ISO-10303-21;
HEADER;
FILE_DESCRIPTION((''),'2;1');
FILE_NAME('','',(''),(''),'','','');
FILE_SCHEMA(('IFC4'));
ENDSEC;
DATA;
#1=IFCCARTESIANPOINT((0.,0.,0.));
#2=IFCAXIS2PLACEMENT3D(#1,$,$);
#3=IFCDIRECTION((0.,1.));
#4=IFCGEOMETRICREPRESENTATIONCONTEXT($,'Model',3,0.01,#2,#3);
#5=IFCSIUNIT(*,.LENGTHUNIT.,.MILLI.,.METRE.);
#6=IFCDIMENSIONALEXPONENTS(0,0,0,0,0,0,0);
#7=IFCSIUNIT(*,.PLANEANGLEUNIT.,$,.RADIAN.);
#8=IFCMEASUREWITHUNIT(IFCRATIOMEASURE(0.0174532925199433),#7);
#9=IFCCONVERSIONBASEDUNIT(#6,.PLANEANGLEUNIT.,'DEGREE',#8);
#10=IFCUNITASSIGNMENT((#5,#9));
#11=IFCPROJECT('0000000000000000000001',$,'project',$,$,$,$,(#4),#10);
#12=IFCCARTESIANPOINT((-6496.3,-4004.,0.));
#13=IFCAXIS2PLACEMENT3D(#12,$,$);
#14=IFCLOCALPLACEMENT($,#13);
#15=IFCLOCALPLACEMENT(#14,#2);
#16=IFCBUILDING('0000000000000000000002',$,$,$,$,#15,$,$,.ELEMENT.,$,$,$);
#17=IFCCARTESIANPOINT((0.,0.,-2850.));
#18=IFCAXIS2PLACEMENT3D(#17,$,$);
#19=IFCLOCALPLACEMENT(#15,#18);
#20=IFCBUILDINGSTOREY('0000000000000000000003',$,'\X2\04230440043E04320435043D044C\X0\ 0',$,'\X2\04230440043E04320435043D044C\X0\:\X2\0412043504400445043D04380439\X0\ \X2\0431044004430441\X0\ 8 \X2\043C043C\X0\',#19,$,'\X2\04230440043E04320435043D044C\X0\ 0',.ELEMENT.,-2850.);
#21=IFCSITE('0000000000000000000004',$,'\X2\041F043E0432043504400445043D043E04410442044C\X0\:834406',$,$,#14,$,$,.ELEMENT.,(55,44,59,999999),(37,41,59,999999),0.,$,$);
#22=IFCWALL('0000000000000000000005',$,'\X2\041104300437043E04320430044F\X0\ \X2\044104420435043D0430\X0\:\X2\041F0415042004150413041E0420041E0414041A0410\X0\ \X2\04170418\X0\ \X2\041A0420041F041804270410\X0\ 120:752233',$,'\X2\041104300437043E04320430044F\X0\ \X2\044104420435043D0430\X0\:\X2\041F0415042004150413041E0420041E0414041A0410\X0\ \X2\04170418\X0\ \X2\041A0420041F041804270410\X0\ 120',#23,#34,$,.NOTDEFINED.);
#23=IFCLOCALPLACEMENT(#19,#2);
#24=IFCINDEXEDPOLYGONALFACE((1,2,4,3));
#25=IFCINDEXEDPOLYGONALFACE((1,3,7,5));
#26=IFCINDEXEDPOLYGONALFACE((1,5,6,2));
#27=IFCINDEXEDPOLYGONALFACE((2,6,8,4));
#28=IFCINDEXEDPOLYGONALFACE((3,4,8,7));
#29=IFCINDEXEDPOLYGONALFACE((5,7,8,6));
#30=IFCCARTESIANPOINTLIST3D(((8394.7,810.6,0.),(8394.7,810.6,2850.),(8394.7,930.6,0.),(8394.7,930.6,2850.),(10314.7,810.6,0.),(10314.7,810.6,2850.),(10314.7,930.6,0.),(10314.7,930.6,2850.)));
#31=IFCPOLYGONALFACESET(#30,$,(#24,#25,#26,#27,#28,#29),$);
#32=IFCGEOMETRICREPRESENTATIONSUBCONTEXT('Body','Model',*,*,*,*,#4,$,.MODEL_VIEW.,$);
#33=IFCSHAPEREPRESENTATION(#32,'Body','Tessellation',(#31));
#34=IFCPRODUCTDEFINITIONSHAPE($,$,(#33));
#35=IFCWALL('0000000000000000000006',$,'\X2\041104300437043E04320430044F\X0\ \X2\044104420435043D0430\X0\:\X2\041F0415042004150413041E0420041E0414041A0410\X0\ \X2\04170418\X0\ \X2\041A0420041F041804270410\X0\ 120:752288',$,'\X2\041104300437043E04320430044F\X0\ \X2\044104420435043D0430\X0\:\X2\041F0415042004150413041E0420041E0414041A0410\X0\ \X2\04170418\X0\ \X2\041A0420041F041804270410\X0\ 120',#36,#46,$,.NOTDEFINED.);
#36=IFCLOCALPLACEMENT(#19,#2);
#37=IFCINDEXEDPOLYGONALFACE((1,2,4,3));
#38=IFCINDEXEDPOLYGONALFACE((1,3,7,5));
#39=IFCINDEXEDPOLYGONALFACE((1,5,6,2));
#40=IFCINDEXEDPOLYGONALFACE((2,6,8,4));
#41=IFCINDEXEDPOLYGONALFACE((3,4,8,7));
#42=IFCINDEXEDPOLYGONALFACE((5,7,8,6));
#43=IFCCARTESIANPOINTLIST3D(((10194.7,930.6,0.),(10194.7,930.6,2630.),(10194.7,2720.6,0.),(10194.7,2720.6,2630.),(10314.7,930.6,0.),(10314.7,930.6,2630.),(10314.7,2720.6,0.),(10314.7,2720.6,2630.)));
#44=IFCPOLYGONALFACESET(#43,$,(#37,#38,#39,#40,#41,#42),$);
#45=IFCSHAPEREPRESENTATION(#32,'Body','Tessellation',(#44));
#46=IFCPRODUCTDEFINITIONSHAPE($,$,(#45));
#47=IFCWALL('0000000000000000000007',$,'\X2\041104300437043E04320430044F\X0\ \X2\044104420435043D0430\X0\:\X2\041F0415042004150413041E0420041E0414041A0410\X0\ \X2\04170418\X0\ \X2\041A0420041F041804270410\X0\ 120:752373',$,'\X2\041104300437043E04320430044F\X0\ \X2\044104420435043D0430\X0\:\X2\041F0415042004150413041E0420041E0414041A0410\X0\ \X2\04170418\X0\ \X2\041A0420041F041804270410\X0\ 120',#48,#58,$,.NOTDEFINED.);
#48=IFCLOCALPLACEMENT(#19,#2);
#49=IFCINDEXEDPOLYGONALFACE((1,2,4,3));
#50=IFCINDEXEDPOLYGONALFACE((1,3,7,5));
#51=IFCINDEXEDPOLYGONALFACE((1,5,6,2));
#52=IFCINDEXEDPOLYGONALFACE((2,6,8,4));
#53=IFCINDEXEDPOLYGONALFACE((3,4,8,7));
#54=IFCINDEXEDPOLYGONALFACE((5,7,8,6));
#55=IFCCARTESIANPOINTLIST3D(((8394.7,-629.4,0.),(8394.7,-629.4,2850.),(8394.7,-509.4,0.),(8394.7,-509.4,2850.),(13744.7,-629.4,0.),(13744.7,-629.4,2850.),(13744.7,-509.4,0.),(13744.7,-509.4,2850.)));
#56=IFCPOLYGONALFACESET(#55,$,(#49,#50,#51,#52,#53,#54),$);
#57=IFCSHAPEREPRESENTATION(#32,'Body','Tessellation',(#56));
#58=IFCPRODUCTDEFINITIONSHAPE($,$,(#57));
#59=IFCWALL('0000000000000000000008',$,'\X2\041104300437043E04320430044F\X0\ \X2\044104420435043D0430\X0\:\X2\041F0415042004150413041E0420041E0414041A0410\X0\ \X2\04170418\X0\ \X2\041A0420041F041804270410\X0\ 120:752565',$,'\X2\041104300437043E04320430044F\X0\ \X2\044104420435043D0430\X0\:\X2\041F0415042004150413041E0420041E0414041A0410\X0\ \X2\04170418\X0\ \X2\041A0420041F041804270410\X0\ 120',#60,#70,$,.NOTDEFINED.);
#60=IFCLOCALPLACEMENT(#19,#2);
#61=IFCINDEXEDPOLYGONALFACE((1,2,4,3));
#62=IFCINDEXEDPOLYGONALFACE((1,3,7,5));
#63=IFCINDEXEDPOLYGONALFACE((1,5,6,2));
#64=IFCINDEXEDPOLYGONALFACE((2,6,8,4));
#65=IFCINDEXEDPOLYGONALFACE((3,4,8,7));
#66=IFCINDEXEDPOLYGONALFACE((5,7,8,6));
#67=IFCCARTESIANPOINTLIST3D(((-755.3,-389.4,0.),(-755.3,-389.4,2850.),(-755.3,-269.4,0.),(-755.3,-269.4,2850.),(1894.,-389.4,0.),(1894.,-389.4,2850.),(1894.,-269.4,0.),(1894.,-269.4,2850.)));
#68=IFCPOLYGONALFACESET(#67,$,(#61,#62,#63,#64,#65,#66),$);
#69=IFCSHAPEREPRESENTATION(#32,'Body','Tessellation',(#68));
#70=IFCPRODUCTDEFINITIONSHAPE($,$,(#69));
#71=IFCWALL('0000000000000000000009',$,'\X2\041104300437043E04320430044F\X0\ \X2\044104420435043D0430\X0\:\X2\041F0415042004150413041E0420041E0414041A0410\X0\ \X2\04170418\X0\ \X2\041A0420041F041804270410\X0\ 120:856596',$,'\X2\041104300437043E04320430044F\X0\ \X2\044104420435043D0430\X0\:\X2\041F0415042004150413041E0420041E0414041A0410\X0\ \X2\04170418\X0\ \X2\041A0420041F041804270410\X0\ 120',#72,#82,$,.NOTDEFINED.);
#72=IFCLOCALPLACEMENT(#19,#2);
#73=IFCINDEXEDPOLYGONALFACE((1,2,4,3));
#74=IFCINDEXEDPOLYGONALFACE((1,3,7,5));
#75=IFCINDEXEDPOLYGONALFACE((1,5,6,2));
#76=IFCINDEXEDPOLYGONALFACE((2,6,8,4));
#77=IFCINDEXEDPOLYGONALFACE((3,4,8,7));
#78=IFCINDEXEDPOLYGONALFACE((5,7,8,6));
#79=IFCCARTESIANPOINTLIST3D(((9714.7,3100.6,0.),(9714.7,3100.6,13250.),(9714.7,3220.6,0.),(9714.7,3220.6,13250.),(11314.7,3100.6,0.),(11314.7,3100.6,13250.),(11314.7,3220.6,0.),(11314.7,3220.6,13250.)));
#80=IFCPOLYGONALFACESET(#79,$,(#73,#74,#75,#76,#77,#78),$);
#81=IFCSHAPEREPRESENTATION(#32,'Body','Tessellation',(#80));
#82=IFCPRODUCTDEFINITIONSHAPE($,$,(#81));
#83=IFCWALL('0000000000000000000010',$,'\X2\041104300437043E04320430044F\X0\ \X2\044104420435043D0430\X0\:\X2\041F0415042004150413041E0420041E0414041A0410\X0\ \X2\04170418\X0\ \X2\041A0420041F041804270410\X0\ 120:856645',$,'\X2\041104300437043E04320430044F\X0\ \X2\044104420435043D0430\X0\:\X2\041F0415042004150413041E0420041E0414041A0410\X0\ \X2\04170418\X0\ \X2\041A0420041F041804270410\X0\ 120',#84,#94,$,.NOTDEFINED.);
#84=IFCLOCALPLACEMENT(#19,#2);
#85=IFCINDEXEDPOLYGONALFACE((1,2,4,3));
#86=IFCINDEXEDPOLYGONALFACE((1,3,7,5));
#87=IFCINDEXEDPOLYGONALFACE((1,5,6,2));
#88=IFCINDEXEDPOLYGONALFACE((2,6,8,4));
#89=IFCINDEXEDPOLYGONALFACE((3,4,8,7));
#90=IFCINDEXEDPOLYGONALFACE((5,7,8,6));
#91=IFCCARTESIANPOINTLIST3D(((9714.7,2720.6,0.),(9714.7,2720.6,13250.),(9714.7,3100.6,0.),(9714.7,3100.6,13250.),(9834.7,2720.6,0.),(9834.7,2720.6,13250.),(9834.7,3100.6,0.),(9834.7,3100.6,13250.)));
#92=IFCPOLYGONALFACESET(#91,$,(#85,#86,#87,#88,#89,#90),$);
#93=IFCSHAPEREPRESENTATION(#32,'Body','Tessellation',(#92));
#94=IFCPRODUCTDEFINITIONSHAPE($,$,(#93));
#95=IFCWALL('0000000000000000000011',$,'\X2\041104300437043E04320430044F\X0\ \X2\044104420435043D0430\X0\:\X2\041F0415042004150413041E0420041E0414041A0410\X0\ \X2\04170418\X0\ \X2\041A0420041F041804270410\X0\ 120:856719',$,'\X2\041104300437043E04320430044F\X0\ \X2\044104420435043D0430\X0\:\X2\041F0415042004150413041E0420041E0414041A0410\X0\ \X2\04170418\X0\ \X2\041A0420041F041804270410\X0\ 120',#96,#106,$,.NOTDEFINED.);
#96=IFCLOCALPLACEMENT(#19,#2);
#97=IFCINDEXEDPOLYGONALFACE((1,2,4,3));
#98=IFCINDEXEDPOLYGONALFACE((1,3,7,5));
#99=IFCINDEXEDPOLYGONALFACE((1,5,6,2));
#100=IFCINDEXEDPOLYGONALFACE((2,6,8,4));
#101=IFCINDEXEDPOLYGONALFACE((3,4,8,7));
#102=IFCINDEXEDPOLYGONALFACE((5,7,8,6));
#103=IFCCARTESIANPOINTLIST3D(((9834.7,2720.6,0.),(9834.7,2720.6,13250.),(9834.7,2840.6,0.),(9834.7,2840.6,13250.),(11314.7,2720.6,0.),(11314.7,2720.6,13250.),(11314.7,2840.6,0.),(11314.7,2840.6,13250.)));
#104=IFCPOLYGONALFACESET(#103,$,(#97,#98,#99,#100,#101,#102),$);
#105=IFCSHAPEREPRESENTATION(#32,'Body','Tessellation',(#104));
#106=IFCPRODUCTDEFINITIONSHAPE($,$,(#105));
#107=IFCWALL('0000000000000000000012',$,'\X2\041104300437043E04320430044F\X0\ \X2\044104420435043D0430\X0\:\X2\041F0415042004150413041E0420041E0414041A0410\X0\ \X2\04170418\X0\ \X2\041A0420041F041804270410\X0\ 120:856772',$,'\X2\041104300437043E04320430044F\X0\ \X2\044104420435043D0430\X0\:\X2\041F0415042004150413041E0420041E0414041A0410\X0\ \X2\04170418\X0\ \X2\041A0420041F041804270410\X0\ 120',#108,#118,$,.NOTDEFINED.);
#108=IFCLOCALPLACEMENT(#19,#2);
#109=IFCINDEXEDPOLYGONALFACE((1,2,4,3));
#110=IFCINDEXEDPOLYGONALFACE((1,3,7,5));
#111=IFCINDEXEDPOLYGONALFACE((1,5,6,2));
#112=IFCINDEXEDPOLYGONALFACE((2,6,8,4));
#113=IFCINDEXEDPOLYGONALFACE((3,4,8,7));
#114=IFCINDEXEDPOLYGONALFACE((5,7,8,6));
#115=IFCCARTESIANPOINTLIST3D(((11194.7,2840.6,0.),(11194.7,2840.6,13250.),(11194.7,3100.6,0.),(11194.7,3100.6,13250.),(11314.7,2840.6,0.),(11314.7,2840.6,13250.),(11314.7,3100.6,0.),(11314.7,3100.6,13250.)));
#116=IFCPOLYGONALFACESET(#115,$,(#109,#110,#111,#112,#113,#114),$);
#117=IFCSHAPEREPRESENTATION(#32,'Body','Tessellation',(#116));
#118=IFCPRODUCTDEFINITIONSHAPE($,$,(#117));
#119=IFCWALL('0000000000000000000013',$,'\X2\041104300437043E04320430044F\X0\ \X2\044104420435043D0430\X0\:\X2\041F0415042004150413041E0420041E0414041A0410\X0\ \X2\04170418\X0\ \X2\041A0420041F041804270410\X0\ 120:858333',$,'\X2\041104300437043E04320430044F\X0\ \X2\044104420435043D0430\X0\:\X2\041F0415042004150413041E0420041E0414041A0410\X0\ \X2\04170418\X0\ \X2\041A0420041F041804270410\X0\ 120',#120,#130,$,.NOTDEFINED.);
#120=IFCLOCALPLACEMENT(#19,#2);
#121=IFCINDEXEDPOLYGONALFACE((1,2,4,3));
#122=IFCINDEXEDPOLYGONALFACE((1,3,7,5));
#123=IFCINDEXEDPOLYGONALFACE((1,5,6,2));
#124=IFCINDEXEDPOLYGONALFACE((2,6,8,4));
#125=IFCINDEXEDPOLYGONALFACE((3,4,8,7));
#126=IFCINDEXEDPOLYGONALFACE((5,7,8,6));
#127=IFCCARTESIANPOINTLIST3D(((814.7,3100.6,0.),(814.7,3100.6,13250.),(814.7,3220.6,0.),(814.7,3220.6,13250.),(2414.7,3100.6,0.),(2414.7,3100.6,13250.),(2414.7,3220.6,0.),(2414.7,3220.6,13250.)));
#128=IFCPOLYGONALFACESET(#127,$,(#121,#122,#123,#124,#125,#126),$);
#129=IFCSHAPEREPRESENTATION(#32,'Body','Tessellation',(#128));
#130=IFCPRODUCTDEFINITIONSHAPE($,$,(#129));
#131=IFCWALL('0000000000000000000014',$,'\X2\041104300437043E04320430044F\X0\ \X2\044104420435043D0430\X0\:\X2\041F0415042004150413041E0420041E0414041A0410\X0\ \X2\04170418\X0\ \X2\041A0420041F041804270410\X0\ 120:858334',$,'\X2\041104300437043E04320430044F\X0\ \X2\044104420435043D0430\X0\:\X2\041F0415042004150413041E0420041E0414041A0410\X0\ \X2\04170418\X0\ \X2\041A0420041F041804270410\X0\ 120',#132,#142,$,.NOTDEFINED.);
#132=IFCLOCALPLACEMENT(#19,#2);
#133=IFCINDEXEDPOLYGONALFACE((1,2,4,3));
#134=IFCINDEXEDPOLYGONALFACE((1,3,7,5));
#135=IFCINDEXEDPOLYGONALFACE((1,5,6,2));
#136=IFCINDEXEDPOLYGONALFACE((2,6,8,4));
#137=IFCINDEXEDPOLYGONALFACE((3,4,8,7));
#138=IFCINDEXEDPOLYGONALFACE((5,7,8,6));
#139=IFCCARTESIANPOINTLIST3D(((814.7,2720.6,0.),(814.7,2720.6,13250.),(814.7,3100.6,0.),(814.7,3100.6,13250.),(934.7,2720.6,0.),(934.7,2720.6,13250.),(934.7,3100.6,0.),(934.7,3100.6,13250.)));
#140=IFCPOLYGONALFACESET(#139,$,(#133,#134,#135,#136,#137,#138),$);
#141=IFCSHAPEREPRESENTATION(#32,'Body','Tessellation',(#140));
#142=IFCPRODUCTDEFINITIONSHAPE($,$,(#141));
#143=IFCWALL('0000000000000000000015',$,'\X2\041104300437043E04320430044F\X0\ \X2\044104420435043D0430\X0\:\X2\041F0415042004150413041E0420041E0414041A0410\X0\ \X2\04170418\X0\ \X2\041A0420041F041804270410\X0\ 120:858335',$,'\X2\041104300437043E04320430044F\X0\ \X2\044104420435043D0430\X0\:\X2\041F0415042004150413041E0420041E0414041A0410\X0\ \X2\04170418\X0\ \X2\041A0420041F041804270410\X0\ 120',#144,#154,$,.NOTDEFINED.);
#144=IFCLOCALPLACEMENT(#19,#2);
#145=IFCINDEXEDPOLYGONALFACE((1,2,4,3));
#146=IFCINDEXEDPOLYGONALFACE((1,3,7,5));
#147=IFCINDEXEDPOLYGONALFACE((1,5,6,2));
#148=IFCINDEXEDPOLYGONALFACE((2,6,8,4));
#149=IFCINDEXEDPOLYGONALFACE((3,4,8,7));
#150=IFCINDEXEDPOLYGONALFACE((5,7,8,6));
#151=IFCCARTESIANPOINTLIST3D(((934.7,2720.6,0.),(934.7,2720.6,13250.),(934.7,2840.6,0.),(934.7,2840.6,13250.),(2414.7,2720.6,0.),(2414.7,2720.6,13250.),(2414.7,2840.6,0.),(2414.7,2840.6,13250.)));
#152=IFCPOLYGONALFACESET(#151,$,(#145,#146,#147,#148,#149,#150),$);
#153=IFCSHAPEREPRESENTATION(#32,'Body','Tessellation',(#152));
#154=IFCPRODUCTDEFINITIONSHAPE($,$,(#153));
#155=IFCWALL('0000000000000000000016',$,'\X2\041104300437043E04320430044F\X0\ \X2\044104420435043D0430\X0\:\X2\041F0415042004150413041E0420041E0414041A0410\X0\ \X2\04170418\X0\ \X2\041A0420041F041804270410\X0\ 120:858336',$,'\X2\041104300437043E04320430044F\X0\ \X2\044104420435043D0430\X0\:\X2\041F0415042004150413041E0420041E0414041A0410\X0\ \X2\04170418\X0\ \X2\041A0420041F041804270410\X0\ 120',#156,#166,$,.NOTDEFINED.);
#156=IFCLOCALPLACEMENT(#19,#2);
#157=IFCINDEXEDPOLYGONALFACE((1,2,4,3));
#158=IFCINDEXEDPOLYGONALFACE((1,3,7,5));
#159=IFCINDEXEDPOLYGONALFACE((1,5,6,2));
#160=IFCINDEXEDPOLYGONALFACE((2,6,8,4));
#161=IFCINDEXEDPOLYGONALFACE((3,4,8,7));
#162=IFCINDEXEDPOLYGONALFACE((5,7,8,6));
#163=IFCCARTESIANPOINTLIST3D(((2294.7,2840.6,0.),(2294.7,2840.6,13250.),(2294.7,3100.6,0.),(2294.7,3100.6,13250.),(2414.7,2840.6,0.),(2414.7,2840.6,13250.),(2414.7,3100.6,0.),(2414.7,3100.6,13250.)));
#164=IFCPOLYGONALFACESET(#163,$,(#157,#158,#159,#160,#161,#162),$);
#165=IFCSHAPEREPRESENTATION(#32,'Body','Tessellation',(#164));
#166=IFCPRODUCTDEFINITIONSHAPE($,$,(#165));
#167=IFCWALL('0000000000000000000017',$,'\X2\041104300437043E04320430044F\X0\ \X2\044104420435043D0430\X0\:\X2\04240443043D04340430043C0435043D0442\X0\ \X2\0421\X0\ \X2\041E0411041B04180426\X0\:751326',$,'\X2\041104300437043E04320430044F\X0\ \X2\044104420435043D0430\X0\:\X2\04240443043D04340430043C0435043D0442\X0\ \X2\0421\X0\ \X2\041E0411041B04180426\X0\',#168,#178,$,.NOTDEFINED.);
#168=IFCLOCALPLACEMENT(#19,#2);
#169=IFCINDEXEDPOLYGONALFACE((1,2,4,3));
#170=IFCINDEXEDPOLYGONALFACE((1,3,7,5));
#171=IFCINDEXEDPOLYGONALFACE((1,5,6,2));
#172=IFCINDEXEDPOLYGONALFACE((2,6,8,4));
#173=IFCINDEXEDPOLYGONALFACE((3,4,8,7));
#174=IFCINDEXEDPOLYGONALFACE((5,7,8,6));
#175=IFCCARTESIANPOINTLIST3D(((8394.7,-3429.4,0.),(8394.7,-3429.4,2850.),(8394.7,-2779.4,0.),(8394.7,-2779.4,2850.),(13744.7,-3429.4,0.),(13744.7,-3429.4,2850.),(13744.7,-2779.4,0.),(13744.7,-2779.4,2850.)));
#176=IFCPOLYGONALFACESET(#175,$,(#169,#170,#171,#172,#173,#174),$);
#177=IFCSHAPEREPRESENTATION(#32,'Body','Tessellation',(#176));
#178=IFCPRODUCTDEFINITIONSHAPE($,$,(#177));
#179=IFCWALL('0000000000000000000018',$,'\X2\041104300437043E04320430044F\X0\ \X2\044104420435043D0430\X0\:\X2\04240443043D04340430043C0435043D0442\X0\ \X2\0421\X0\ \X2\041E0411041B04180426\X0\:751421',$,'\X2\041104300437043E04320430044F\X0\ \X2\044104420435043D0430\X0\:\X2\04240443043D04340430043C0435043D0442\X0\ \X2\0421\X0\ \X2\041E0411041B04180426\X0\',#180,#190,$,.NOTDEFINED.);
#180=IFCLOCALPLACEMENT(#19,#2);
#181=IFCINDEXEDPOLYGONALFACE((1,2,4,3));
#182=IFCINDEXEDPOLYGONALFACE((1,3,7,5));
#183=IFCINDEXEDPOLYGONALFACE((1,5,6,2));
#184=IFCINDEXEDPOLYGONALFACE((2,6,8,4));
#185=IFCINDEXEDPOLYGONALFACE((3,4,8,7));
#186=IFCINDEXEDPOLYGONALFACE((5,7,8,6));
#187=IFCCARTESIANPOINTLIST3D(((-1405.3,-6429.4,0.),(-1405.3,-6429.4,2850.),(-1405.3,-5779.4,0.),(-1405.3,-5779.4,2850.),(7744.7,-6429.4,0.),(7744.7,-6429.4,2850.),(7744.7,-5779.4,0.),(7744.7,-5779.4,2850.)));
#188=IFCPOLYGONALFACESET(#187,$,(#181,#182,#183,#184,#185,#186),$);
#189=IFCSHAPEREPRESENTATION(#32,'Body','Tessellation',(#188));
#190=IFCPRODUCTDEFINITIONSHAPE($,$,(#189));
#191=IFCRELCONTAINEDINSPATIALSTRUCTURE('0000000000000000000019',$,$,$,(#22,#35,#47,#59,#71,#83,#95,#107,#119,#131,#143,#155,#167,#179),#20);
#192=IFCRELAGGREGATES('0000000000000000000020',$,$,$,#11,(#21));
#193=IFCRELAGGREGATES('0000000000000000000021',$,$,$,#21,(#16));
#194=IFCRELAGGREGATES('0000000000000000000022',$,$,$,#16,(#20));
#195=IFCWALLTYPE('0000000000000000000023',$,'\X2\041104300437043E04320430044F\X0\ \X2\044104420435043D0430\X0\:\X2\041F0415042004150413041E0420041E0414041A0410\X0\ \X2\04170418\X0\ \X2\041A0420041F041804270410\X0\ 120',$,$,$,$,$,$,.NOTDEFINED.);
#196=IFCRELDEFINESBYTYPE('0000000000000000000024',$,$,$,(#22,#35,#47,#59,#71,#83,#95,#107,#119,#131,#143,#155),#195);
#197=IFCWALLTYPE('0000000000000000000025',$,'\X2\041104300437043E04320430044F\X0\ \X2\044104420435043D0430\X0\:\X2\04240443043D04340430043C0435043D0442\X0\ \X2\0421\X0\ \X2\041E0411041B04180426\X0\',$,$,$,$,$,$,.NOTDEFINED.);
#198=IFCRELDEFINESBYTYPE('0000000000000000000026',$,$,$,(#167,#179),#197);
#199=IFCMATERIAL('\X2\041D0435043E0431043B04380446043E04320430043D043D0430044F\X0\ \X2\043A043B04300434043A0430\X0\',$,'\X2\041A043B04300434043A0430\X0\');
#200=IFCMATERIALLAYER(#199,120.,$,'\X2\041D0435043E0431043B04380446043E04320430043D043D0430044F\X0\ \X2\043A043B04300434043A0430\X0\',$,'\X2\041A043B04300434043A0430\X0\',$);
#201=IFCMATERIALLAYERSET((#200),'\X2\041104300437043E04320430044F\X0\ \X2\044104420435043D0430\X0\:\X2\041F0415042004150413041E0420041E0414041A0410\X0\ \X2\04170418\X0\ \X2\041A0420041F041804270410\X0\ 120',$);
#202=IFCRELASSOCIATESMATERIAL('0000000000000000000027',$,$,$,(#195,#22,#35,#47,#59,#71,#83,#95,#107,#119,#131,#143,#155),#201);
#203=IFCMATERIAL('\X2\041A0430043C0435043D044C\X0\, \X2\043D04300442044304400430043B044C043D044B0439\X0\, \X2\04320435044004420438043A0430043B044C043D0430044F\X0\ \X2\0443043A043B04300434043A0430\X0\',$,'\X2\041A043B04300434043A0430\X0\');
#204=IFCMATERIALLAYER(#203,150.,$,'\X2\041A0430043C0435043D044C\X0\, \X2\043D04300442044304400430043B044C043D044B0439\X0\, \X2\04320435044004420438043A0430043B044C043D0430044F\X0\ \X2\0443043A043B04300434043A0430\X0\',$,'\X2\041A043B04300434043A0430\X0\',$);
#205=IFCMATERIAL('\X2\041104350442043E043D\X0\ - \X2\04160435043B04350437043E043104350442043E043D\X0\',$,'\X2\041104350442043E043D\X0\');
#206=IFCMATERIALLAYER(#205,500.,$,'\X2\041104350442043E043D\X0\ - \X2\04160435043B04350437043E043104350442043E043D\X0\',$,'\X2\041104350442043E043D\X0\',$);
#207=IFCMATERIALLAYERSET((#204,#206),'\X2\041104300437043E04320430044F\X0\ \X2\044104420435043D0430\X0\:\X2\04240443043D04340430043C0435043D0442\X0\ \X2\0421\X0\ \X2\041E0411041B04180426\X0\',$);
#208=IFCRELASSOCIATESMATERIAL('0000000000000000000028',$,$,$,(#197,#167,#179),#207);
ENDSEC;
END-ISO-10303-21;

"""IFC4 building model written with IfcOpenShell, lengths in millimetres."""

from ifc_helpers import new_model, entity, si_unit, converted_unit, direction, frame, origin, place, context, subcontext, project, spatial, indexed_curve, outline, extrude, material, layer, layer_set, type_object, element, save


model = new_model("IFC4")

# Units and contexts
model_context = context("Model", 3, precision=0.01, world=origin(), true_north=direction((0.0, 1.0)))
body_context = subcontext(model_context, "Body", "Model", "MODEL_VIEW")
ifc_project = project(units=[si_unit("LENGTHUNIT", "METRE", prefix="MILLI"), converted_unit("PLANEANGLEUNIT", "DEGREE", entity("IfcRatioMeasure", 0.0174532925199433), si_unit("PLANEANGLEUNIT", "RADIAN"), dimensions=[0, 0, 0, 0, 0, 0, 0])], contexts=[model_context])

# Site, building, storey
site_placement = place(None, frame((-6496.3, -4004.0, 0.0)))
site = spatial("IfcSite", under=ifc_project, at=site_placement, Name="Поверхность:834406", CompositionType="ELEMENT", RefLatitude=(55, 44, 59, 999999), RefLongitude=(37, 41, 59, 999999), RefElevation=0.0)
building_placement = place(site_placement, origin())
building = spatial("IfcBuilding", under=site, at=building_placement, CompositionType="ELEMENT")
storey_placement = place(building_placement, frame((0.0, 0.0, -2850.0)))
storey = spatial("IfcBuildingStorey", under=building, at=storey_placement, Name="Уровень 0", ObjectType="Уровень:Верхний брус 8 мм", LongName="Уровень 0", CompositionType="ELEMENT", Elevation=-2850.0)

# Shared definitions
ifc_material_1 = material(Name="Бетон - Железобетон", Category="Бетон")

# Walls
ifc_material_2 = material(Name="Необлицованная кладка", Category="Кладка")
ifc_layer_1 = layer(ifc_material_2, 120.0, Name="Необлицованная кладка", Category="Кладка")
ifc_layer_set_1 = layer_set([ifc_layer_1], Name="Базовая стена:ПЕРЕГОРОДКА ЗИ КРПИЧА 120")
wall_type_1 = type_object("IfcWallType", Name="Базовая стена:ПЕРЕГОРОДКА ЗИ КРПИЧА 120", PredefinedType="NOTDEFINED", material=ifc_layer_set_1)
wall_1_placement = place(storey_placement, frame((8394.7, 870.6, 0.0)))
element("IfcWall", 1, at=wall_1_placement, inside=storey, type_object=wall_type_1, material=ifc_layer_set_1, Name="Базовая стена:ПЕРЕГОРОДКА ЗИ КРПИЧА 120:752233", ObjectType="Базовая стена:ПЕРЕГОРОДКА ЗИ КРПИЧА 120", PredefinedType="NOTDEFINED", context=body_context, shape_type="SweptSolid", body=[
    extrude(outline(indexed_curve([(1920.0, 60.0), (0.0, 60.0), (0.0, -60.0), (1920.0, -60.0), (1920.0, 60.0)], self_intersect=False)), origin(), (0.0, 0.0, 1.0), 2850.0),
])
wall_2_placement = place(storey_placement, frame((10254.7, 930.6, 0.0), z_axis=(0.0, 0.0, 1.0), x_axis=(0.0, 1.0, 0.0)))
element("IfcWall", 2, at=wall_2_placement, inside=storey, type_object=wall_type_1, material=ifc_layer_set_1, Name="Базовая стена:ПЕРЕГОРОДКА ЗИ КРПИЧА 120:752288", ObjectType="Базовая стена:ПЕРЕГОРОДКА ЗИ КРПИЧА 120", PredefinedType="NOTDEFINED", context=body_context, shape_type="SweptSolid", body=[
    extrude(outline(indexed_curve([(1790.0, 60.0), (0.0, 60.0), (0.0, -60.0), (1790.0, -60.0), (1790.0, 60.0)], self_intersect=False)), origin(), (0.0, 0.0, 1.0), 2630.0),
])
wall_3_placement = place(storey_placement, frame((8394.7, -569.4, 0.0)))
element("IfcWall", 3, at=wall_3_placement, inside=storey, type_object=wall_type_1, material=ifc_layer_set_1, Name="Базовая стена:ПЕРЕГОРОДКА ЗИ КРПИЧА 120:752373", ObjectType="Базовая стена:ПЕРЕГОРОДКА ЗИ КРПИЧА 120", PredefinedType="NOTDEFINED", context=body_context, shape_type="SweptSolid", body=[
    extrude(outline(indexed_curve([(5350.0, 60.0), (0.0, 60.0), (0.0, -60.0), (5350.0, -60.0), (5350.0, 60.0)], self_intersect=False)), origin(), (0.0, 0.0, 1.0), 2850.0),
])
wall_4_placement = place(storey_placement, frame((1894.0, -329.4, 0.0), z_axis=(0.0, 0.0, 1.0), x_axis=(-1.0, 0.0, 0.0)))
element("IfcWall", 4, at=wall_4_placement, inside=storey, type_object=wall_type_1, material=ifc_layer_set_1, Name="Базовая стена:ПЕРЕГОРОДКА ЗИ КРПИЧА 120:752565", ObjectType="Базовая стена:ПЕРЕГОРОДКА ЗИ КРПИЧА 120", PredefinedType="NOTDEFINED", context=body_context, shape_type="SweptSolid", body=[
    extrude(outline(indexed_curve([(2649.4, 60.0), (0.0, 60.0), (0.0, -60.0), (2649.4, -60.0), (2649.4, 60.0)], self_intersect=False)), origin(), (0.0, 0.0, 1.0), 2850.0),
])
wall_5_placement = place(storey_placement, frame((11314.7, 3160.6, 0.0), z_axis=(0.0, 0.0, 1.0), x_axis=(-1.0, 0.0, 0.0)))
element("IfcWall", 5, at=wall_5_placement, inside=storey, type_object=wall_type_1, material=ifc_layer_set_1, Name="Базовая стена:ПЕРЕГОРОДКА ЗИ КРПИЧА 120:856596", ObjectType="Базовая стена:ПЕРЕГОРОДКА ЗИ КРПИЧА 120", PredefinedType="NOTDEFINED", context=body_context, shape_type="SweptSolid", body=[
    extrude(outline(indexed_curve([(1600.0, 60.0), (0.0, 60.0), (0.0, -60.0), (1600.0, -60.0), (1600.0, 60.0)], self_intersect=False)), origin(), (0.0, 0.0, 1.0), 13250.0),
])
wall_6_placement = place(storey_placement, frame((9774.7, 3100.6, 0.0), z_axis=(0.0, 0.0, 1.0), x_axis=(0.0, -1.0, 0.0)))
element("IfcWall", 6, at=wall_6_placement, inside=storey, type_object=wall_type_1, material=ifc_layer_set_1, Name="Базовая стена:ПЕРЕГОРОДКА ЗИ КРПИЧА 120:856645", ObjectType="Базовая стена:ПЕРЕГОРОДКА ЗИ КРПИЧА 120", PredefinedType="NOTDEFINED", context=body_context, shape_type="SweptSolid", body=[
    extrude(outline(indexed_curve([(380.0, 60.0), (0.0, 60.0), (0.0, -60.0), (380.0, -60.0), (380.0, 60.0)], self_intersect=False)), origin(), (0.0, 0.0, 1.0), 13250.0),
])
wall_7_placement = place(storey_placement, frame((9834.7, 2780.6, 0.0)))
element("IfcWall", 7, at=wall_7_placement, inside=storey, type_object=wall_type_1, material=ifc_layer_set_1, Name="Базовая стена:ПЕРЕГОРОДКА ЗИ КРПИЧА 120:856719", ObjectType="Базовая стена:ПЕРЕГОРОДКА ЗИ КРПИЧА 120", PredefinedType="NOTDEFINED", context=body_context, shape_type="SweptSolid", body=[
    extrude(outline(indexed_curve([(1480.0, 60.0), (0.0, 60.0), (0.0, -60.0), (1480.0, -60.0), (1480.0, 60.0)], self_intersect=False)), origin(), (0.0, 0.0, 1.0), 13250.0),
])
wall_8_placement = place(storey_placement, frame((11254.7, 2840.6, 0.0), z_axis=(0.0, 0.0, 1.0), x_axis=(0.0, 1.0, 0.0)))
element("IfcWall", 8, at=wall_8_placement, inside=storey, type_object=wall_type_1, material=ifc_layer_set_1, Name="Базовая стена:ПЕРЕГОРОДКА ЗИ КРПИЧА 120:856772", ObjectType="Базовая стена:ПЕРЕГОРОДКА ЗИ КРПИЧА 120", PredefinedType="NOTDEFINED", context=body_context, shape_type="SweptSolid", body=[
    extrude(outline(indexed_curve([(260.0, 60.0), (0.0, 60.0), (0.0, -60.0), (260.0, -60.0), (260.0, 60.0)], self_intersect=False)), origin(), (0.0, 0.0, 1.0), 13250.0),
])
wall_9_placement = place(storey_placement, frame((2414.7, 3160.6, 0.0), z_axis=(0.0, 0.0, 1.0), x_axis=(-1.0, 0.0, 0.0)))
element("IfcWall", 9, at=wall_9_placement, inside=storey, type_object=wall_type_1, material=ifc_layer_set_1, Name="Базовая стена:ПЕРЕГОРОДКА ЗИ КРПИЧА 120:858333", ObjectType="Базовая стена:ПЕРЕГОРОДКА ЗИ КРПИЧА 120", PredefinedType="NOTDEFINED", context=body_context, shape_type="SweptSolid", body=[
    extrude(outline(indexed_curve([(1600.0, 60.0), (0.0, 60.0), (0.0, -60.0), (1600.0, -60.0), (1600.0, 60.0)], self_intersect=False)), origin(), (0.0, 0.0, 1.0), 13250.0),
])
wall_10_placement = place(storey_placement, frame((874.7, 3100.6, 0.0), z_axis=(0.0, 0.0, 1.0), x_axis=(0.0, -1.0, 0.0)))
element("IfcWall", 10, at=wall_10_placement, inside=storey, type_object=wall_type_1, material=ifc_layer_set_1, Name="Базовая стена:ПЕРЕГОРОДКА ЗИ КРПИЧА 120:858334", ObjectType="Базовая стена:ПЕРЕГОРОДКА ЗИ КРПИЧА 120", PredefinedType="NOTDEFINED", context=body_context, shape_type="SweptSolid", body=[
    extrude(outline(indexed_curve([(380.0, 60.0), (0.0, 60.0), (0.0, -60.0), (380.0, -60.0), (380.0, 60.0)], self_intersect=False)), origin(), (0.0, 0.0, 1.0), 13250.0),
])
wall_11_placement = place(storey_placement, frame((934.7, 2780.6, 0.0)))
element("IfcWall", 11, at=wall_11_placement, inside=storey, type_object=wall_type_1, material=ifc_layer_set_1, Name="Базовая стена:ПЕРЕГОРОДКА ЗИ КРПИЧА 120:858335", ObjectType="Базовая стена:ПЕРЕГОРОДКА ЗИ КРПИЧА 120", PredefinedType="NOTDEFINED", context=body_context, shape_type="SweptSolid", body=[
    extrude(outline(indexed_curve([(1480.0, 60.0), (0.0, 60.0), (0.0, -60.0), (1480.0, -60.0), (1480.0, 60.0)], self_intersect=False)), origin(), (0.0, 0.0, 1.0), 13250.0),
])
wall_12_placement = place(storey_placement, frame((2354.7, 2840.6, 0.0), z_axis=(0.0, 0.0, 1.0), x_axis=(0.0, 1.0, 0.0)))
element("IfcWall", 12, at=wall_12_placement, inside=storey, type_object=wall_type_1, material=ifc_layer_set_1, Name="Базовая стена:ПЕРЕГОРОДКА ЗИ КРПИЧА 120:858336", ObjectType="Базовая стена:ПЕРЕГОРОДКА ЗИ КРПИЧА 120", PredefinedType="NOTDEFINED", context=body_context, shape_type="SweptSolid", body=[
    extrude(outline(indexed_curve([(260.0, 60.0), (0.0, 60.0), (0.0, -60.0), (260.0, -60.0), (260.0, 60.0)], self_intersect=False)), origin(), (0.0, 0.0, 1.0), 13250.0),
])
ifc_material_3 = material(Name="Камень, натуральный, вертикальная укладка", Category="Кладка")
ifc_layer_2 = layer(ifc_material_3, 150.0, Name="Камень, натуральный, вертикальная укладка", Category="Кладка")
ifc_layer_3 = layer(ifc_material_1, 500.0, Name="Бетон - Железобетон", Category="Бетон")
ifc_layer_set_2 = layer_set([ifc_layer_2, ifc_layer_3], Name="Базовая стена:Фундамент С ОБЛИЦ")
wall_type_2 = type_object("IfcWallType", Name="Базовая стена:Фундамент С ОБЛИЦ", PredefinedType="NOTDEFINED", material=ifc_layer_set_2)
wall_13_placement = place(storey_placement, frame((13744.7, -3104.4, 0.0), z_axis=(0.0, 0.0, 1.0), x_axis=(-1.0, 0.0, 0.0)))
element("IfcWall", 13, at=wall_13_placement, inside=storey, type_object=wall_type_2, material=ifc_layer_set_2, Name="Базовая стена:Фундамент С ОБЛИЦ:751326", ObjectType="Базовая стена:Фундамент С ОБЛИЦ", PredefinedType="NOTDEFINED", context=body_context, shape_type="SweptSolid", body=[
    extrude(outline(indexed_curve([(5350.0, 325.0), (0.0, 325.0), (0.0, -325.0), (5350.0, -325.0), (5350.0, 325.0)], self_intersect=False)), origin(), (0.0, 0.0, 1.0), 2850.0),
])
wall_14_placement = place(storey_placement, frame((7744.7, -6104.4, 0.0), z_axis=(0.0, 0.0, 1.0), x_axis=(-1.0, 0.0, 0.0)))
element("IfcWall", 14, at=wall_14_placement, inside=storey, type_object=wall_type_2, material=ifc_layer_set_2, Name="Базовая стена:Фундамент С ОБЛИЦ:751421", ObjectType="Базовая стена:Фундамент С ОБЛИЦ", PredefinedType="NOTDEFINED", context=body_context, shape_type="SweptSolid", body=[
    extrude(outline(indexed_curve([(9150.0, 325.0), (0.0, 325.0), (0.0, -325.0), (9150.0, -325.0), (9150.0, 325.0)], self_intersect=False)), origin(), (0.0, 0.0, 1.0), 2850.0),
])

save(model, "model.ifc")
